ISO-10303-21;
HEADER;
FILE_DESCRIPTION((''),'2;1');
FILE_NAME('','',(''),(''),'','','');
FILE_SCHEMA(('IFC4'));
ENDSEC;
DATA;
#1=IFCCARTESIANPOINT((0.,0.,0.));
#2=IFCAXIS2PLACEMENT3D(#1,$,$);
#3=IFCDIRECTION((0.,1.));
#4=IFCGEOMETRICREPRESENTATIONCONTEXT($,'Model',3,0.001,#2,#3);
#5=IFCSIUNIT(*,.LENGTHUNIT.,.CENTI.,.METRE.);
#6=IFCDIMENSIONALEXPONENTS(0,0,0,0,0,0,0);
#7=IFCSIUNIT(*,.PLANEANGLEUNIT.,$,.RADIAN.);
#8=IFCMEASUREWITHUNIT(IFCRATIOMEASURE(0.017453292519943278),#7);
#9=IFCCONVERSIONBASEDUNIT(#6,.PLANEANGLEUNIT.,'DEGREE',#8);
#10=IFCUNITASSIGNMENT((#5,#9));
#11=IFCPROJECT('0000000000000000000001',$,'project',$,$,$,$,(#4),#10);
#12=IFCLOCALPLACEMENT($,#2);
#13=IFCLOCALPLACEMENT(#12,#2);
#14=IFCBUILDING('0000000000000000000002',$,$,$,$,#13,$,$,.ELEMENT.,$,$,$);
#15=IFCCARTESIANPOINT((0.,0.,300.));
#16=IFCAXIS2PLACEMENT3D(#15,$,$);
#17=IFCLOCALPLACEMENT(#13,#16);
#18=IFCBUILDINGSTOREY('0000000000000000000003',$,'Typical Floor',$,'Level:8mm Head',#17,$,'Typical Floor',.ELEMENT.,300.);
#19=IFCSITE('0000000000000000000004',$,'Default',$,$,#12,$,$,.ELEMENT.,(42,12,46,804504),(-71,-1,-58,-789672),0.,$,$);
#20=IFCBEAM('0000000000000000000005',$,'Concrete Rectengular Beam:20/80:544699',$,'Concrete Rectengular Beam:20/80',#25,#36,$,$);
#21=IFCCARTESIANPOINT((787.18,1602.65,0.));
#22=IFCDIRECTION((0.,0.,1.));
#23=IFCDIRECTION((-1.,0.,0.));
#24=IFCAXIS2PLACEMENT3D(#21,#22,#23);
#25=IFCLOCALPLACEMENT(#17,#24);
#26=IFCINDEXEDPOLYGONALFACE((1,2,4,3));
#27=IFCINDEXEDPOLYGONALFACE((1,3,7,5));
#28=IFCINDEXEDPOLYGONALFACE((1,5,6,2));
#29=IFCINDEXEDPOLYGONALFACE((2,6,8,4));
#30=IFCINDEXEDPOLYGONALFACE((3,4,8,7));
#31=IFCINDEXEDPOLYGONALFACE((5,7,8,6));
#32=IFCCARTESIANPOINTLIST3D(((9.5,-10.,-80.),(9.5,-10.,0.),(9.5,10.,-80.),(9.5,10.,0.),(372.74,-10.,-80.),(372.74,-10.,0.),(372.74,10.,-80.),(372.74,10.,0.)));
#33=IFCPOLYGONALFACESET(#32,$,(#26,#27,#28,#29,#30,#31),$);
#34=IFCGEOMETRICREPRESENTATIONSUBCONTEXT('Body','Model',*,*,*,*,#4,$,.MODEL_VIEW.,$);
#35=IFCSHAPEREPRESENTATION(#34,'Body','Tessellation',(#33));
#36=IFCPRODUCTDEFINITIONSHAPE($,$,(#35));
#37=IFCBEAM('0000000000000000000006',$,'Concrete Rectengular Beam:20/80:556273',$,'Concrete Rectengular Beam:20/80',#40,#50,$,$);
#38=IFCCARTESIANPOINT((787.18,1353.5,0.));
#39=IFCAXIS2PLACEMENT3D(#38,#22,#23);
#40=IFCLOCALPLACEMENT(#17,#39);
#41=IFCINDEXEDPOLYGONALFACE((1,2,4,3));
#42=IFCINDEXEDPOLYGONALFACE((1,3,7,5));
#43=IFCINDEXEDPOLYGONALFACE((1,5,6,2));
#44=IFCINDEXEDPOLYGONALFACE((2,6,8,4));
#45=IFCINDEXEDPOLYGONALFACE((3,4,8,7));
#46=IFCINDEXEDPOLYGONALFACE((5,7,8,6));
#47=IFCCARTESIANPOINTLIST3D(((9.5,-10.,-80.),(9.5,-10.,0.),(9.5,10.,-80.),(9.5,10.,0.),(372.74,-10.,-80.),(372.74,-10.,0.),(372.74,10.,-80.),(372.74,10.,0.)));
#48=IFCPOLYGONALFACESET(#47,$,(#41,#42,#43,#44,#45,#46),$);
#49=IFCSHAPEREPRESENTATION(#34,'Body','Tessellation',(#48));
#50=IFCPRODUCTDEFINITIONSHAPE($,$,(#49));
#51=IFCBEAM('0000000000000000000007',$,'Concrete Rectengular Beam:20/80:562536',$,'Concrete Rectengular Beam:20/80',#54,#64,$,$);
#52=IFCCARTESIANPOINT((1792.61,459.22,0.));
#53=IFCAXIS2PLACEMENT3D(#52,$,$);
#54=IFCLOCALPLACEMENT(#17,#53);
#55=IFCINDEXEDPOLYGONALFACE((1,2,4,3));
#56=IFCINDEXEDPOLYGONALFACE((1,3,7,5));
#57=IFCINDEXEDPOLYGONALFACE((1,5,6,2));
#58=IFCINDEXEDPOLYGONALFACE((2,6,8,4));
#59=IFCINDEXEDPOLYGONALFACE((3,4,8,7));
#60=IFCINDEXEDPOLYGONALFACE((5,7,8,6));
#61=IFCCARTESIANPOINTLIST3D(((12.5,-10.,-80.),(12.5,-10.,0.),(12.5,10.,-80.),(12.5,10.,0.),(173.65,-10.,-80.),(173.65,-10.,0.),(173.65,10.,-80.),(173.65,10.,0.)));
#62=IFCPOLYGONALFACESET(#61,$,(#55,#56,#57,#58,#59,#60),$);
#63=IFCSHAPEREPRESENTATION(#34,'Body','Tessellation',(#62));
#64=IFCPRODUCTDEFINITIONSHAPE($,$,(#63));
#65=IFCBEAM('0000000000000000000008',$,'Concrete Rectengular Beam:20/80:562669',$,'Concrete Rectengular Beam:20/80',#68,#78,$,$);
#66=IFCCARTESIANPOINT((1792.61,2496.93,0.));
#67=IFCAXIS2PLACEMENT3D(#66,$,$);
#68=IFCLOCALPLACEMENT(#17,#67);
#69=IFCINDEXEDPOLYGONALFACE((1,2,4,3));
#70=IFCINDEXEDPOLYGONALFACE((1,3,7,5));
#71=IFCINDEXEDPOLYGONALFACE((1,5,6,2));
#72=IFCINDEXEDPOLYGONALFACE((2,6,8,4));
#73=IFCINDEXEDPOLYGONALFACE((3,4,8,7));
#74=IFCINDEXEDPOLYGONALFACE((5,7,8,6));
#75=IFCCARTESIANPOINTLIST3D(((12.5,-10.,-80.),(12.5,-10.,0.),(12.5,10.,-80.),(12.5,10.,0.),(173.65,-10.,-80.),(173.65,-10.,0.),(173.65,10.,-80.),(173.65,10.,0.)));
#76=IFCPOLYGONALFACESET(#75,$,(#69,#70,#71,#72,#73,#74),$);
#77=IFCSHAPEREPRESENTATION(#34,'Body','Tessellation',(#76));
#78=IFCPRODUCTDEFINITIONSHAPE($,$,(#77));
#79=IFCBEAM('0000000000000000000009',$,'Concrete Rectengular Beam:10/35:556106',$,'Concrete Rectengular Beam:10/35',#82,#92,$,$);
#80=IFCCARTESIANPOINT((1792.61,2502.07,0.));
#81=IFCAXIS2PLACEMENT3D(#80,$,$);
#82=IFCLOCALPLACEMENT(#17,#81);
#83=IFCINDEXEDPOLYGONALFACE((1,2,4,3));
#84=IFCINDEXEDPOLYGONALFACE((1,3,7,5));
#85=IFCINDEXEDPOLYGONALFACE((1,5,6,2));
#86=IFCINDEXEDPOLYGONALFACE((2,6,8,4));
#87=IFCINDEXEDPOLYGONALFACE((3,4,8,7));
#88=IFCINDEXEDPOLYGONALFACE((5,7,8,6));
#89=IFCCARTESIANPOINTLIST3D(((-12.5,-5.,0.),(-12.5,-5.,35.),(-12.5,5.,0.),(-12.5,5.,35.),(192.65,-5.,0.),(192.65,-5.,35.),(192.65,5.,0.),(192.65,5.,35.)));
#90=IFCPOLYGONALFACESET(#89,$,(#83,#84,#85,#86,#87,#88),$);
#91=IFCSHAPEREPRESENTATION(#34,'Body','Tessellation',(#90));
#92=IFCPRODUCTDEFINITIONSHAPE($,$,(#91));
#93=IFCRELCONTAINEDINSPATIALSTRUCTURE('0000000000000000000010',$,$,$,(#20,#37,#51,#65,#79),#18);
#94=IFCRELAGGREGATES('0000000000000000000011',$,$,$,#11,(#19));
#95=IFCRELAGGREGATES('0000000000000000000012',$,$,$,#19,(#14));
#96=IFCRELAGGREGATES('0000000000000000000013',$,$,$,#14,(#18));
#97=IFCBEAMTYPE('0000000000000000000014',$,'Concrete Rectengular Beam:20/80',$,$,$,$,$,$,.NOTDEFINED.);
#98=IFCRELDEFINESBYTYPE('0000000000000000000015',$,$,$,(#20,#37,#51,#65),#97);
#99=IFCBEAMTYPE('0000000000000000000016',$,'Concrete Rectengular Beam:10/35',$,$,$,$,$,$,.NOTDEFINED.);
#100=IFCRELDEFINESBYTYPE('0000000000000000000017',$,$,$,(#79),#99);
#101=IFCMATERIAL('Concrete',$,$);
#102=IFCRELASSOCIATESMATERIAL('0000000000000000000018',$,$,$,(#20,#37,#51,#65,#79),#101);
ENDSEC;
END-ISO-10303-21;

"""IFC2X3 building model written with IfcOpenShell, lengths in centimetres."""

from ifc_helpers import new_model, entity, si_unit, converted_unit, direction, frame, frame_2d, origin, place, context, subcontext, project, spatial, rectangle, extrude, material, type_object, element, save


model = new_model("IFC2X3")

# Units and contexts
model_context = context("Model", 3, precision=0.001, world=origin(), true_north=direction((0.0, 1.0)))
body_context = subcontext(model_context, "Body", "Model", "MODEL_VIEW")
ifc_project = project(units=[si_unit("LENGTHUNIT", "METRE", prefix="CENTI"), converted_unit("PLANEANGLEUNIT", "DEGREE", entity("IfcRatioMeasure", 0.017453292519943278), si_unit("PLANEANGLEUNIT", "RADIAN"), dimensions=[0, 0, 0, 0, 0, 0, 0])], contexts=[model_context])

# Site, building, storey
site_placement = place(None, origin())
site = spatial("IfcSite", under=ifc_project, at=site_placement, Name="Default", CompositionType="ELEMENT", RefLatitude=(42, 12, 46, 804504), RefLongitude=(-71, -1, -58, -789672), RefElevation=0.0)
building_placement = place(site_placement, origin())
building = spatial("IfcBuilding", under=site, at=building_placement, CompositionType="ELEMENT")
storey_placement = place(building_placement, frame((0.0, 0.0, 300.0)))
storey = spatial("IfcBuildingStorey", under=building, at=storey_placement, Name="Typical Floor", ObjectType="Level:8mm Head", LongName="Typical Floor", CompositionType="ELEMENT", Elevation=300.0)

# Beams
ifc_material = material(Name="Concrete")
beam_type_1 = type_object("IfcBeamType", Name="Concrete Rectengular Beam:20/80", PredefinedType="NOTDEFINED")
beam_1_placement = place(storey_placement, frame((787.18, 1602.65, 0.0), z_axis=(0.0, 0.0, 1.0), x_axis=(-1.0, 0.0, 0.0)))
element("IfcBeam", 1, at=beam_1_placement, inside=storey, type_object=beam_type_1, material=ifc_material, Name="Concrete Rectengular Beam:20/80:544699", ObjectType="Concrete Rectengular Beam:20/80", context=body_context, shape_type="SweptSolid", body=[
    extrude(rectangle(XDim=80.0, YDim=20.0, at=frame_2d((0.0, 0.0), x_axis=(1.0, 0.0))), frame((9.5, 0.0, -40.0), z_axis=(1.0, 0.0, 0.0), x_axis=(0.0, 0.0, -1.0)), (0.0, 0.0, 1.0), 363.24),
])
beam_2_placement = place(storey_placement, frame((787.18, 1353.5, 0.0), z_axis=(0.0, 0.0, 1.0), x_axis=(-1.0, 0.0, 0.0)))
element("IfcBeam", 2, at=beam_2_placement, inside=storey, type_object=beam_type_1, material=ifc_material, Name="Concrete Rectengular Beam:20/80:556273", ObjectType="Concrete Rectengular Beam:20/80", context=body_context, shape_type="SweptSolid", body=[
    extrude(rectangle(XDim=80.0, YDim=20.0, at=frame_2d((0.0, 0.0), x_axis=(1.0, 0.0))), frame((9.5, 0.0, -40.0), z_axis=(1.0, 0.0, 0.0), x_axis=(0.0, 0.0, -1.0)), (0.0, 0.0, 1.0), 363.24),
])
beam_3_placement = place(storey_placement, frame((1792.61, 459.22, 0.0)))
element("IfcBeam", 3, at=beam_3_placement, inside=storey, type_object=beam_type_1, material=ifc_material, Name="Concrete Rectengular Beam:20/80:562536", ObjectType="Concrete Rectengular Beam:20/80", context=body_context, shape_type="SweptSolid", body=[
    extrude(rectangle(XDim=80.0, YDim=20.0, at=frame_2d((0.0, 0.0), x_axis=(1.0, 0.0))), frame((12.5, 0.0, -40.0), z_axis=(1.0, 0.0, 0.0), x_axis=(0.0, 0.0, -1.0)), (0.0, 0.0, 1.0), 161.15),
])
beam_4_placement = place(storey_placement, frame((1792.61, 2496.93, 0.0)))
element("IfcBeam", 4, at=beam_4_placement, inside=storey, type_object=beam_type_1, material=ifc_material, Name="Concrete Rectengular Beam:20/80:562669", ObjectType="Concrete Rectengular Beam:20/80", context=body_context, shape_type="SweptSolid", body=[
    extrude(rectangle(XDim=80.0, YDim=20.0, at=frame_2d((0.0, 0.0), x_axis=(1.0, 0.0))), frame((12.5, 0.0, -40.0), z_axis=(1.0, 0.0, 0.0), x_axis=(0.0, 0.0, -1.0)), (0.0, 0.0, 1.0), 161.15),
])
beam_type_2 = type_object("IfcBeamType", Name="Concrete Rectengular Beam:10/35", PredefinedType="NOTDEFINED")
beam_5_placement = place(storey_placement, frame((1792.61, 2502.07, 0.0)))
element("IfcBeam", 5, at=beam_5_placement, inside=storey, type_object=beam_type_2, material=ifc_material, Name="Concrete Rectengular Beam:10/35:556106", ObjectType="Concrete Rectengular Beam:10/35", context=body_context, shape_type="SweptSolid", body=[
    extrude(rectangle(XDim=35.0, YDim=10.0, at=frame_2d((0.0, 0.0), x_axis=(1.0, 0.0))), frame((-12.5, 0.0, 17.5), z_axis=(1.0, 0.0, 0.0), x_axis=(0.0, 0.0, -1.0)), (0.0, 0.0, 1.0), 205.15),
])

save(model, "model.ifc")
